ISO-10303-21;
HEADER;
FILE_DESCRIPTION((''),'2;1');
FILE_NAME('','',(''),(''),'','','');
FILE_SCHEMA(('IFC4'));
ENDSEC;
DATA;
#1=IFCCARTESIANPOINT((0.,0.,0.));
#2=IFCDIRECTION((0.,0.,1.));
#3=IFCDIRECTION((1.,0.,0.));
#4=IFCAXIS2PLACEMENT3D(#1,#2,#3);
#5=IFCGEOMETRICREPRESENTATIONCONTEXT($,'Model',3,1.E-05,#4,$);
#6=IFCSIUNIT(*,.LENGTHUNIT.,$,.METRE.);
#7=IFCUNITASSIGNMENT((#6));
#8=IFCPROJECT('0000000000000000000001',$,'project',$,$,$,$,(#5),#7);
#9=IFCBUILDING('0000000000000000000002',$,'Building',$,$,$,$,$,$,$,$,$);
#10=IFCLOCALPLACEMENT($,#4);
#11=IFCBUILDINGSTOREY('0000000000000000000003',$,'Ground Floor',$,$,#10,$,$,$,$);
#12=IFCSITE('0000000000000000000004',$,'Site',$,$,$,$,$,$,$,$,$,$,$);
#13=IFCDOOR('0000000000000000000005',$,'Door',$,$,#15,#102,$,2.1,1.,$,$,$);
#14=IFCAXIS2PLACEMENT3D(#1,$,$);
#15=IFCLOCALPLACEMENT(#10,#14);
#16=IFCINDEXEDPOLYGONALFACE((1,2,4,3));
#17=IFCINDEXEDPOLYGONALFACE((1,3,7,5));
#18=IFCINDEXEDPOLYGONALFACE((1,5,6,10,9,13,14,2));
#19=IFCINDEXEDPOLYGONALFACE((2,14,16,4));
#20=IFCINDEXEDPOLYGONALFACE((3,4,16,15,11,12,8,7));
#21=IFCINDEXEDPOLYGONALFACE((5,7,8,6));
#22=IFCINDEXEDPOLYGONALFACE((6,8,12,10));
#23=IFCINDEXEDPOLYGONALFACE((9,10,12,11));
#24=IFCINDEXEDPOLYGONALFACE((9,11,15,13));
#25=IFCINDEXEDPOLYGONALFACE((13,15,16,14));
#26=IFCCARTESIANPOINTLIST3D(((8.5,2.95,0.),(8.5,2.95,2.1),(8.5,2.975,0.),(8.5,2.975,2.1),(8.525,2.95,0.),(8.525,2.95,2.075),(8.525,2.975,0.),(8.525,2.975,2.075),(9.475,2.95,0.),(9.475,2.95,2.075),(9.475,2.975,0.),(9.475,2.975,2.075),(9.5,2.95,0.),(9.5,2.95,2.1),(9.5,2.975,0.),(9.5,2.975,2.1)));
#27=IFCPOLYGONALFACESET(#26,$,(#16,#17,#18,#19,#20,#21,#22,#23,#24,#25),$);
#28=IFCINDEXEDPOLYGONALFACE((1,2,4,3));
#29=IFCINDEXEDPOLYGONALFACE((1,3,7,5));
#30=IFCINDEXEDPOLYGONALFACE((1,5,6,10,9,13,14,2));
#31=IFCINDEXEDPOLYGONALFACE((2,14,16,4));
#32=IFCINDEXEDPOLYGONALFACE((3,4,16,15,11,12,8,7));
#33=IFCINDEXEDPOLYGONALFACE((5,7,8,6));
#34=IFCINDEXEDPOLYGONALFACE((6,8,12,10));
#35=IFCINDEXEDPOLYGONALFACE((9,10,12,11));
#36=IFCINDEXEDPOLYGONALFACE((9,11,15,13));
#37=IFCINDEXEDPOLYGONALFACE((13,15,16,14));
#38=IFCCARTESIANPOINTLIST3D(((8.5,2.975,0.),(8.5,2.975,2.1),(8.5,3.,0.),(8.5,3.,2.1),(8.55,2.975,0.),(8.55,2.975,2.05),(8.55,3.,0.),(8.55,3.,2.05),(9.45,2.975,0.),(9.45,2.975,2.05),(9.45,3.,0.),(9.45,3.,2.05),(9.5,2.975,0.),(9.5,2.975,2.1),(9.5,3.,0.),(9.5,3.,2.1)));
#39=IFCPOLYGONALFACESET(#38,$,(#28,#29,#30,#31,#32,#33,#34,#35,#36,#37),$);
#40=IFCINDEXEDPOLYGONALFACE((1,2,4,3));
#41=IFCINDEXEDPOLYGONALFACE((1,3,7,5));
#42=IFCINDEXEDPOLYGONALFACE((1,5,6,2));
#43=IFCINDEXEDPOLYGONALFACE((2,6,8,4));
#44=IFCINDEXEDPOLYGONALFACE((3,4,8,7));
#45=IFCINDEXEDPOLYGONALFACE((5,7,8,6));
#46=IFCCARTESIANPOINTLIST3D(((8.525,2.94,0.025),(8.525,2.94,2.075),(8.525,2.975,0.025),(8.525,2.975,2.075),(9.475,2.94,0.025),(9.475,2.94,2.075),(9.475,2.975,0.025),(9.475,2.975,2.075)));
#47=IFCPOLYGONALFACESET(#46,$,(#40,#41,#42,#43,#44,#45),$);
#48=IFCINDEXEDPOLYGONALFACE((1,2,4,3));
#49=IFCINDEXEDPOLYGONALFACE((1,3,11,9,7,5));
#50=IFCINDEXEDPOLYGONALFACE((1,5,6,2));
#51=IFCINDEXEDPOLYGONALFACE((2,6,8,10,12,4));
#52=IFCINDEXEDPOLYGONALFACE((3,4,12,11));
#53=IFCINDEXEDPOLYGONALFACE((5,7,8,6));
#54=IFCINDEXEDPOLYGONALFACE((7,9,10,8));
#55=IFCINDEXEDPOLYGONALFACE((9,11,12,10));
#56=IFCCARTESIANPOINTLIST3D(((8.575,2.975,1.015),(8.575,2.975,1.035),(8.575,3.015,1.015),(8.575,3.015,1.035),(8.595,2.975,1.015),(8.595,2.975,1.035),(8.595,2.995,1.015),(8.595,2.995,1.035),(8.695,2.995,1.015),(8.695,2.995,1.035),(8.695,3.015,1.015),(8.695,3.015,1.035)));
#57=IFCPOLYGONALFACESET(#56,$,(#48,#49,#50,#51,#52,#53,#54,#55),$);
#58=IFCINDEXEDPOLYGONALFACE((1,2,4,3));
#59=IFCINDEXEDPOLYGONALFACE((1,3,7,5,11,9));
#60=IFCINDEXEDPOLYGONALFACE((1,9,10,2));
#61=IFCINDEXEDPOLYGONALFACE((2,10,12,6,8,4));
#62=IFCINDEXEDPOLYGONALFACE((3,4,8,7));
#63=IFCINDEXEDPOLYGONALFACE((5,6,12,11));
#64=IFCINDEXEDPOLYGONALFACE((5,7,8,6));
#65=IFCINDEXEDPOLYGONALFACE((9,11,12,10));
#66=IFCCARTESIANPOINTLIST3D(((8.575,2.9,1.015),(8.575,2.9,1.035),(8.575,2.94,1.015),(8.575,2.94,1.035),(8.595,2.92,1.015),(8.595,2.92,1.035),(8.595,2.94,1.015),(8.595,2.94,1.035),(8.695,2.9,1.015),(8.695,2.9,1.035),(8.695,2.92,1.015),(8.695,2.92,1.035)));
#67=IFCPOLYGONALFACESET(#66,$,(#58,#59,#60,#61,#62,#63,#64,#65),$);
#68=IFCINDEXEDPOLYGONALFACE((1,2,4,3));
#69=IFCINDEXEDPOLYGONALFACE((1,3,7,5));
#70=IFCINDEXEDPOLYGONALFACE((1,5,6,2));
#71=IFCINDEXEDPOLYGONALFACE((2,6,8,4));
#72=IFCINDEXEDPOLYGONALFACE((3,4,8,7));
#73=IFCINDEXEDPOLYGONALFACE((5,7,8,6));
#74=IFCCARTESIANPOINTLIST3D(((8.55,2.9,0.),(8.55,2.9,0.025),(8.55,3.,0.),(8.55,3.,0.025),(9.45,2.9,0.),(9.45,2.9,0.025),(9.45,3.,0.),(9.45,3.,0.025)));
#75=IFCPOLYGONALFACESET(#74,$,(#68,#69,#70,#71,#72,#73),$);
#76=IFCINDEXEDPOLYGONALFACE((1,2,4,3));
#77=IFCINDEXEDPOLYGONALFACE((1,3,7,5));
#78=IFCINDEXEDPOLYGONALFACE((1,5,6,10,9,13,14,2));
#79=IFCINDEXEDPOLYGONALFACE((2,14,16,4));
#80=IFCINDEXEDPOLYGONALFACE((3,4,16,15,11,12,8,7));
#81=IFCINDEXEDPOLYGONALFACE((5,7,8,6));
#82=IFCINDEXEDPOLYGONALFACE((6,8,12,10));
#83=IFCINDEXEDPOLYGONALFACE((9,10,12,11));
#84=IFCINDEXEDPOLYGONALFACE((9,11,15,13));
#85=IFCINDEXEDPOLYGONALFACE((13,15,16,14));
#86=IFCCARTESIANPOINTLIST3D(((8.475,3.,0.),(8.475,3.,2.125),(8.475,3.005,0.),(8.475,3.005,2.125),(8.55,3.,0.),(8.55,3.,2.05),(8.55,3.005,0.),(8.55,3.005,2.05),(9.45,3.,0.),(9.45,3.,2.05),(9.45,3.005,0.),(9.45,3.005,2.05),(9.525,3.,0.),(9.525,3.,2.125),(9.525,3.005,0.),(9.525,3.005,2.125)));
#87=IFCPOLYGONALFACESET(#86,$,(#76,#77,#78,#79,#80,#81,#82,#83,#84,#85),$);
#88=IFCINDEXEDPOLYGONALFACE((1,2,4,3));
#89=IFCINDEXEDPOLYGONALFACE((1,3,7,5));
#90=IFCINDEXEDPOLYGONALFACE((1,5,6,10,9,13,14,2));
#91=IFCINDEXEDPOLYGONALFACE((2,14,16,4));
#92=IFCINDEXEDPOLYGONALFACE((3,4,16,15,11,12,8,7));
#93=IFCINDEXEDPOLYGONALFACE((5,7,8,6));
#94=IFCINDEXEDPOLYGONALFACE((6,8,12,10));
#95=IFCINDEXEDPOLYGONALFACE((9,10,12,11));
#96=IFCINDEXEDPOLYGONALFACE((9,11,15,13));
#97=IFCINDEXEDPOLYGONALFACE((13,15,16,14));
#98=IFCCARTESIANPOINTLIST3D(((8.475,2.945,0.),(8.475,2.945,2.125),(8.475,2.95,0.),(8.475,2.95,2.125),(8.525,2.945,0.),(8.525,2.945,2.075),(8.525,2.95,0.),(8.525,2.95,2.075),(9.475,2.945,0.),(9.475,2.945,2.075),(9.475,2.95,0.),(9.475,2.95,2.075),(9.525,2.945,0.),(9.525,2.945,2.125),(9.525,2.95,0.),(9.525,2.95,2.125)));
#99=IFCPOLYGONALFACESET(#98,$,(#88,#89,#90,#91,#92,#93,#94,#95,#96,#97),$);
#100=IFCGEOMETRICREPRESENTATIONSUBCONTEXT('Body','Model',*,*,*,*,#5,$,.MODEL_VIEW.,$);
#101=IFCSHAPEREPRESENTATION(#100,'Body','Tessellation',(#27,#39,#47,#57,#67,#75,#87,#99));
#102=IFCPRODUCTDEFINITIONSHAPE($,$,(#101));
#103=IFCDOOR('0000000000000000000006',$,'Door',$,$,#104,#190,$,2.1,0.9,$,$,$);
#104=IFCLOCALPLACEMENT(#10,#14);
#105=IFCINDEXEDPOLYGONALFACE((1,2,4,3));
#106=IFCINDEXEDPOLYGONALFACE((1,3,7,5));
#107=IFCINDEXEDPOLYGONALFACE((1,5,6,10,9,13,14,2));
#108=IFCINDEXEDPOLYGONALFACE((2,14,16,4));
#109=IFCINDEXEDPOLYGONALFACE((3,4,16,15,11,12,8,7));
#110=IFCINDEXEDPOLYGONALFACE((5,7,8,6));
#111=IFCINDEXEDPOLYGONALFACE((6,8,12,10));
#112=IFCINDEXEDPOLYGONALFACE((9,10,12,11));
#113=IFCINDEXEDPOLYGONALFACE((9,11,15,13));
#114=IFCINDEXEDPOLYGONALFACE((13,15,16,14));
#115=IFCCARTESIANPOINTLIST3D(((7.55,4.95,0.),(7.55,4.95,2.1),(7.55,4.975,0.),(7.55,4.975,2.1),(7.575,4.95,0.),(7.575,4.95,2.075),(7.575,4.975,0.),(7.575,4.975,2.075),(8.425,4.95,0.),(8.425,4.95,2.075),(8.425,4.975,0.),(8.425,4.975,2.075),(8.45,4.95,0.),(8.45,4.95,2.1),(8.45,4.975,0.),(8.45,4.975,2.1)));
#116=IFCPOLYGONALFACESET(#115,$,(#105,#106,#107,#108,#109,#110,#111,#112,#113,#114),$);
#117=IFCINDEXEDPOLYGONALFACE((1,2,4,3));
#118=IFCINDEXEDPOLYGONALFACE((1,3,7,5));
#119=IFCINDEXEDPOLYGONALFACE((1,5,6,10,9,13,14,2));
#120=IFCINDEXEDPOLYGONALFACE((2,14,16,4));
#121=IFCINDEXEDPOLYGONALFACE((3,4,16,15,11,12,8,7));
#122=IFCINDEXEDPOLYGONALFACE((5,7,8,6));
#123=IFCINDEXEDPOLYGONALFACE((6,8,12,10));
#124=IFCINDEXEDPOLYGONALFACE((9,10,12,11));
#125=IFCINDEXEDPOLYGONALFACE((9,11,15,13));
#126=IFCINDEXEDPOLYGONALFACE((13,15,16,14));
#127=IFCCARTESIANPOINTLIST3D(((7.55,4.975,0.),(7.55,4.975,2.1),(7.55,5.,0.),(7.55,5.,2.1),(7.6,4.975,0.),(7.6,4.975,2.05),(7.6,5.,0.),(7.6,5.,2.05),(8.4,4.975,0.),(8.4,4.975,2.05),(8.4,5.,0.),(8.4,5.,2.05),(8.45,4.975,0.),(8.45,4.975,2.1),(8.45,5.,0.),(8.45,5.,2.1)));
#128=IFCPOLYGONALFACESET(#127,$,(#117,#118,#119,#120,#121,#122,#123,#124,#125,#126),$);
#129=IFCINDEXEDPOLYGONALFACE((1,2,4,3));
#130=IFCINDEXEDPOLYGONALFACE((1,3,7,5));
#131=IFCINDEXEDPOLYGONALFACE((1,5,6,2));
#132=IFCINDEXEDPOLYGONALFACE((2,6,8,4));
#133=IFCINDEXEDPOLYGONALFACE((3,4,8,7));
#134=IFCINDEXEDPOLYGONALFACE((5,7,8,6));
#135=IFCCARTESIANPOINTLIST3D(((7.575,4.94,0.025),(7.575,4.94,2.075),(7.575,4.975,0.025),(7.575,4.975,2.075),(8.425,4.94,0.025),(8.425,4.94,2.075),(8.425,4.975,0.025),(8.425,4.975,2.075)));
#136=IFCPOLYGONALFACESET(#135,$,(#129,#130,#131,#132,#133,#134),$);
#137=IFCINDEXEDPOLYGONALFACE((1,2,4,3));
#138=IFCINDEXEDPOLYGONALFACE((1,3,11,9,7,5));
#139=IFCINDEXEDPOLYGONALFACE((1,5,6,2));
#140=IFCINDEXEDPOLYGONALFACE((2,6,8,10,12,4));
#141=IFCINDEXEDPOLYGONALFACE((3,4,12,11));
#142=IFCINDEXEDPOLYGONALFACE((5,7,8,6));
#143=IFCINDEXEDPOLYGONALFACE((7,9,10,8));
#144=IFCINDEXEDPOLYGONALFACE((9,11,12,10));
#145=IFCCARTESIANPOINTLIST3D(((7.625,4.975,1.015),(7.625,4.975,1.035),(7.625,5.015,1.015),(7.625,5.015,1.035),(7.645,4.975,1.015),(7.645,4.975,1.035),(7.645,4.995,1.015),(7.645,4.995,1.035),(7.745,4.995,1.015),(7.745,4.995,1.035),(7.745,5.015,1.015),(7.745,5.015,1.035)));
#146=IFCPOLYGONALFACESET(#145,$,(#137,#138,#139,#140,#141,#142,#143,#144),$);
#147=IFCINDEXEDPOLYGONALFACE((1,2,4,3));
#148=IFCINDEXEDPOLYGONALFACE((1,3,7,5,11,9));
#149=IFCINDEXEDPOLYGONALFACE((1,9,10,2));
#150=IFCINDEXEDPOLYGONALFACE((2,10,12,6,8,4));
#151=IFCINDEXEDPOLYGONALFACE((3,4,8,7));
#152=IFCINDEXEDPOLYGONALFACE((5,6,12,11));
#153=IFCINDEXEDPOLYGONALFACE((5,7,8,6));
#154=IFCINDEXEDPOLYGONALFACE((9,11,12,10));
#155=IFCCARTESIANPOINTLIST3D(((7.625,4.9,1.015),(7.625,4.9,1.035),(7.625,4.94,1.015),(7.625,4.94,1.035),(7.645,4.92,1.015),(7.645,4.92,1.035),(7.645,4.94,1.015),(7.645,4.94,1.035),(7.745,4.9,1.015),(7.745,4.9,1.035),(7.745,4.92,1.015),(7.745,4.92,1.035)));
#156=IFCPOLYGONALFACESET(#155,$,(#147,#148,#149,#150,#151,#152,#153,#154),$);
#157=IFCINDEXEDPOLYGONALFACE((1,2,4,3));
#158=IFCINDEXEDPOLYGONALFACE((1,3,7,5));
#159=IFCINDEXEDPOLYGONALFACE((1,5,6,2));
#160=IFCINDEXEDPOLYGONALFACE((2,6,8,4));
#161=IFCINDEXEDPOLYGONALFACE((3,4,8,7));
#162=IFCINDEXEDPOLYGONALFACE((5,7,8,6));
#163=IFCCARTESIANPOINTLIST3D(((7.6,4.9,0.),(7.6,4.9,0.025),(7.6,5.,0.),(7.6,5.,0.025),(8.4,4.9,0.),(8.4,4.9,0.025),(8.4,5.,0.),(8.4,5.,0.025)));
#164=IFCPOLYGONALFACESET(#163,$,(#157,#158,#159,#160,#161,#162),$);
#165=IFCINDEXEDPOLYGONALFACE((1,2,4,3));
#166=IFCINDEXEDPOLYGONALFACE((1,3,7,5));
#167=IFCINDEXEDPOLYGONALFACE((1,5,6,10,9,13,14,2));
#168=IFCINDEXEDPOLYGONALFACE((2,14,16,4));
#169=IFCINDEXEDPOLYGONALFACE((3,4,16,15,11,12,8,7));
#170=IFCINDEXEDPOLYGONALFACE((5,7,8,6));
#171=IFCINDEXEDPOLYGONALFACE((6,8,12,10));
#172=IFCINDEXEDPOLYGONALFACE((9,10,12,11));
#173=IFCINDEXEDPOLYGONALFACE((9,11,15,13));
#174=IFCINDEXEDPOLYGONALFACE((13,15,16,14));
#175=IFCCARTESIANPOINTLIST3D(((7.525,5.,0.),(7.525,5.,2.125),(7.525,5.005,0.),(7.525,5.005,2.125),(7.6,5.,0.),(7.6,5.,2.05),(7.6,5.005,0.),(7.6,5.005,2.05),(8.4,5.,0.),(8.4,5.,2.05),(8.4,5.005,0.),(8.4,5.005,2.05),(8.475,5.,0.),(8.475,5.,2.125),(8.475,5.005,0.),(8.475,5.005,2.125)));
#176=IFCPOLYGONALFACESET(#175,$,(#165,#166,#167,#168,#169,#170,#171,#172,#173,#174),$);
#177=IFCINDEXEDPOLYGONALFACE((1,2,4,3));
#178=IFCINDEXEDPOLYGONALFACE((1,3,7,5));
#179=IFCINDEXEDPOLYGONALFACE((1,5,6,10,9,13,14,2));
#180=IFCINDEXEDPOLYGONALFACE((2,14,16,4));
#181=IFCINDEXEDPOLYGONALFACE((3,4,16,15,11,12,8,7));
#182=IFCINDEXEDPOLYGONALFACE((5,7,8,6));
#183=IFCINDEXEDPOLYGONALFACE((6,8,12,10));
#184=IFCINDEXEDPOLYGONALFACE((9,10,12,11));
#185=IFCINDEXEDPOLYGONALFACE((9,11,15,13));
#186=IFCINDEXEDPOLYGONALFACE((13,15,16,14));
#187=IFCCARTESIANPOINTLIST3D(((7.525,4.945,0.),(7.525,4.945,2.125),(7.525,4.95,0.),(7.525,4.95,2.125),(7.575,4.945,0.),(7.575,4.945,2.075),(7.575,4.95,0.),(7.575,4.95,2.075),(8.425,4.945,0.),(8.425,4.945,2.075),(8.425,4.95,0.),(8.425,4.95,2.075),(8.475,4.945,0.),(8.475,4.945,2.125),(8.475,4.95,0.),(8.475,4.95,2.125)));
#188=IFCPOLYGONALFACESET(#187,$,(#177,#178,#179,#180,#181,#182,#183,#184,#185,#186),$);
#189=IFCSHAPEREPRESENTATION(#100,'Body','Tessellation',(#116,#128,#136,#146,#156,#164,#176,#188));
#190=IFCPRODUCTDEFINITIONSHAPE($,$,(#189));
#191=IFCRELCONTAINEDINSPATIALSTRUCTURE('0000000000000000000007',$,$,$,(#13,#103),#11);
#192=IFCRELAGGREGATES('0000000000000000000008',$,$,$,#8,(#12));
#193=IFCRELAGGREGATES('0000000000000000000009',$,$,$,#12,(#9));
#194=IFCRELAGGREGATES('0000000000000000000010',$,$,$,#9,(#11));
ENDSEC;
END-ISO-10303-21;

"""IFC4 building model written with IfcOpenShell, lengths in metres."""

from ifc_helpers import new_model, si_unit, frame, origin_with_axes, place, context, subcontext, project, spatial, line, indexed_curve, outline, extrude, element, save


model = new_model("IFC4")

# Units and contexts
model_context = context("Model", 3, precision=1e-05, world=origin_with_axes())
body_context = subcontext(model_context, "Body", "Model", "MODEL_VIEW")
ifc_project = project(units=[si_unit("LENGTHUNIT", "METRE")], contexts=[model_context])

# Site, building, storey
site = spatial("IfcSite", under=ifc_project, Name="Site")
building = spatial("IfcBuilding", under=site, Name="Building")
storey_placement = place(None, origin_with_axes())
storey = spatial("IfcBuildingStorey", under=building, at=storey_placement, Name="Ground Floor")

# Doors
door_1_placement = place(storey_placement, frame((9.5, 3.0, 0.0), z_axis=(0.0, 0.0, 1.0), x_axis=(-1.0, 0.0, 0.0)))
element("IfcDoor", 1, at=door_1_placement, inside=storey, Name="Door", OverallHeight=2.1, OverallWidth=1.0, context=body_context, shape_type="SweptSolid", body=[
    extrude(outline(indexed_curve([(0.0, 0.0), (0.0, 2.1), (1.0, 2.1), (1.0, 0.0), (0.975, 0.0), (0.975, 2.075), (0.025, 2.075), (0.025, 0.0)], segments=[line(1, 2, 3, 4, 5, 6, 7, 8, 1)])), frame((0.0, 0.025, 0.0), z_axis=(0.0, -1.0, 0.0), x_axis=(1.0, 0.0, 0.0)), (0.0, 0.0, -1.0), 0.025),
    extrude(outline(indexed_curve([(0.0, 0.0), (0.0, 2.1), (1.0, 2.1), (1.0, 0.0), (0.95, 0.0), (0.95, 2.05), (0.05, 2.05), (0.05, 0.0)], segments=[line(1, 2, 3, 4, 5, 6, 7, 8, 1)])), frame((0.0, 0.0, 0.0), z_axis=(0.0, -1.0, 0.0), x_axis=(1.0, 0.0, 0.0)), (0.0, 0.0, -1.0), 0.025),
    extrude(outline(indexed_curve([(0.0, 0.0), (0.95, 0.0), (0.95, 0.035), (0.0, 0.035)], segments=[line(1, 2, 3, 4, 1)])), frame((0.025, 0.025, 0.025), z_axis=(0.0, 0.0, 1.0), x_axis=(1.0, 0.0, 0.0)), (0.0, 0.0, 1.0), 2.05),
    extrude(outline(indexed_curve([(0.0, 0.0), (0.0, -0.04), (-0.12, -0.04), (-0.12, -0.02), (-0.02, -0.02), (-0.02, 0.0)], segments=[line(1, 2, 3, 4, 5, 6, 1)])), frame((0.925, 0.025, 1.015), z_axis=(0.0, 0.0, 1.0), x_axis=(1.0, 0.0, 0.0)), (0.0, 0.0, 1.0), 0.02),
    extrude(outline(indexed_curve([(0.0, 0.0), (0.0, 0.04), (-0.12, 0.04), (-0.12, 0.02), (-0.02, 0.02), (-0.02, 0.0)], segments=[line(1, 2, 3, 4, 5, 6, 1)])), frame((0.925, 0.06, 1.015), z_axis=(0.0, 0.0, 1.0), x_axis=(1.0, 0.0, 0.0)), (0.0, 0.0, 1.0), 0.02),
    extrude(outline(indexed_curve([(0.0, 0.0), (0.9, 0.0), (0.9, 0.1), (0.0, 0.1)], segments=[line(1, 2, 3, 4, 1)])), frame((0.05, 0.0, 0.0), z_axis=(0.0, 0.0, 1.0), x_axis=(1.0, 0.0, 0.0)), (0.0, 0.0, 1.0), 0.025),
    extrude(outline(indexed_curve([(0.0, 0.0), (0.0, 2.125), (1.05, 2.125), (1.05, 0.0), (0.975, 0.0), (0.975, 2.05), (0.075, 2.05), (0.075, 0.0)], segments=[line(1, 2, 3, 4, 5, 6, 7, 8, 1)])), frame((-0.025, -0.005, 0.0), z_axis=(0.0, -1.0, 0.0), x_axis=(1.0, 0.0, 0.0)), (0.0, 0.0, -1.0), 0.005),
    extrude(outline(indexed_curve([(0.0, 0.0), (0.0, 2.125), (1.05, 2.125), (1.05, 0.0), (1.0, 0.0), (1.0, 2.075), (0.05, 2.075), (0.05, 0.0)], segments=[line(1, 2, 3, 4, 5, 6, 7, 8, 1)])), frame((-0.025, 0.05, 0.0), z_axis=(0.0, -1.0, 0.0), x_axis=(1.0, 0.0, 0.0)), (0.0, 0.0, -1.0), 0.005),
])
door_2_placement = place(storey_placement, frame((8.45, 5.0, 0.0), z_axis=(0.0, 0.0, 1.0), x_axis=(-1.0, 0.0, 0.0)))
element("IfcDoor", 2, at=door_2_placement, inside=storey, Name="Door", OverallHeight=2.1, OverallWidth=0.9, context=body_context, shape_type="SweptSolid", body=[
    extrude(outline(indexed_curve([(0.0, 0.0), (0.0, 2.1), (0.9, 2.1), (0.9, 0.0), (0.875, 0.0), (0.875, 2.075), (0.025, 2.075), (0.025, 0.0)], segments=[line(1, 2, 3, 4, 5, 6, 7, 8, 1)])), frame((0.0, 0.025, 0.0), z_axis=(0.0, -1.0, 0.0), x_axis=(1.0, 0.0, 0.0)), (0.0, 0.0, -1.0), 0.025),
    extrude(outline(indexed_curve([(0.0, 0.0), (0.0, 2.1), (0.9, 2.1), (0.9, 0.0), (0.85, 0.0), (0.85, 2.05), (0.05, 2.05), (0.05, 0.0)], segments=[line(1, 2, 3, 4, 5, 6, 7, 8, 1)])), frame((0.0, 0.0, 0.0), z_axis=(0.0, -1.0, 0.0), x_axis=(1.0, 0.0, 0.0)), (0.0, 0.0, -1.0), 0.025),
    extrude(outline(indexed_curve([(0.0, 0.0), (0.85, 0.0), (0.85, 0.035), (0.0, 0.035)], segments=[line(1, 2, 3, 4, 1)])), frame((0.025, 0.025, 0.025), z_axis=(0.0, 0.0, 1.0), x_axis=(1.0, 0.0, 0.0)), (0.0, 0.0, 1.0), 2.05),
    extrude(outline(indexed_curve([(0.0, 0.0), (0.0, -0.04), (-0.12, -0.04), (-0.12, -0.02), (-0.02, -0.02), (-0.02, 0.0)], segments=[line(1, 2, 3, 4, 5, 6, 1)])), frame((0.825, 0.025, 1.015), z_axis=(0.0, 0.0, 1.0), x_axis=(1.0, 0.0, 0.0)), (0.0, 0.0, 1.0), 0.02),
    extrude(outline(indexed_curve([(0.0, 0.0), (0.0, 0.04), (-0.12, 0.04), (-0.12, 0.02), (-0.02, 0.02), (-0.02, 0.0)], segments=[line(1, 2, 3, 4, 5, 6, 1)])), frame((0.825, 0.06, 1.015), z_axis=(0.0, 0.0, 1.0), x_axis=(1.0, 0.0, 0.0)), (0.0, 0.0, 1.0), 0.02),
    extrude(outline(indexed_curve([(0.0, 0.0), (0.8, 0.0), (0.8, 0.1), (0.0, 0.1)], segments=[line(1, 2, 3, 4, 1)])), frame((0.05, 0.0, 0.0), z_axis=(0.0, 0.0, 1.0), x_axis=(1.0, 0.0, 0.0)), (0.0, 0.0, 1.0), 0.025),
    extrude(outline(indexed_curve([(0.0, 0.0), (0.0, 2.125), (0.95, 2.125), (0.95, 0.0), (0.875, 0.0), (0.875, 2.05), (0.075, 2.05), (0.075, 0.0)], segments=[line(1, 2, 3, 4, 5, 6, 7, 8, 1)])), frame((-0.025, -0.005, 0.0), z_axis=(0.0, -1.0, 0.0), x_axis=(1.0, 0.0, 0.0)), (0.0, 0.0, -1.0), 0.005),
    extrude(outline(indexed_curve([(0.0, 0.0), (0.0, 2.125), (0.95, 2.125), (0.95, 0.0), (0.9, 0.0), (0.9, 2.075), (0.05, 2.075), (0.05, 0.0)], segments=[line(1, 2, 3, 4, 5, 6, 7, 8, 1)])), frame((-0.025, 0.05, 0.0), z_axis=(0.0, -1.0, 0.0), x_axis=(1.0, 0.0, 0.0)), (0.0, 0.0, -1.0), 0.005),
])

save(model, "model.ifc")
